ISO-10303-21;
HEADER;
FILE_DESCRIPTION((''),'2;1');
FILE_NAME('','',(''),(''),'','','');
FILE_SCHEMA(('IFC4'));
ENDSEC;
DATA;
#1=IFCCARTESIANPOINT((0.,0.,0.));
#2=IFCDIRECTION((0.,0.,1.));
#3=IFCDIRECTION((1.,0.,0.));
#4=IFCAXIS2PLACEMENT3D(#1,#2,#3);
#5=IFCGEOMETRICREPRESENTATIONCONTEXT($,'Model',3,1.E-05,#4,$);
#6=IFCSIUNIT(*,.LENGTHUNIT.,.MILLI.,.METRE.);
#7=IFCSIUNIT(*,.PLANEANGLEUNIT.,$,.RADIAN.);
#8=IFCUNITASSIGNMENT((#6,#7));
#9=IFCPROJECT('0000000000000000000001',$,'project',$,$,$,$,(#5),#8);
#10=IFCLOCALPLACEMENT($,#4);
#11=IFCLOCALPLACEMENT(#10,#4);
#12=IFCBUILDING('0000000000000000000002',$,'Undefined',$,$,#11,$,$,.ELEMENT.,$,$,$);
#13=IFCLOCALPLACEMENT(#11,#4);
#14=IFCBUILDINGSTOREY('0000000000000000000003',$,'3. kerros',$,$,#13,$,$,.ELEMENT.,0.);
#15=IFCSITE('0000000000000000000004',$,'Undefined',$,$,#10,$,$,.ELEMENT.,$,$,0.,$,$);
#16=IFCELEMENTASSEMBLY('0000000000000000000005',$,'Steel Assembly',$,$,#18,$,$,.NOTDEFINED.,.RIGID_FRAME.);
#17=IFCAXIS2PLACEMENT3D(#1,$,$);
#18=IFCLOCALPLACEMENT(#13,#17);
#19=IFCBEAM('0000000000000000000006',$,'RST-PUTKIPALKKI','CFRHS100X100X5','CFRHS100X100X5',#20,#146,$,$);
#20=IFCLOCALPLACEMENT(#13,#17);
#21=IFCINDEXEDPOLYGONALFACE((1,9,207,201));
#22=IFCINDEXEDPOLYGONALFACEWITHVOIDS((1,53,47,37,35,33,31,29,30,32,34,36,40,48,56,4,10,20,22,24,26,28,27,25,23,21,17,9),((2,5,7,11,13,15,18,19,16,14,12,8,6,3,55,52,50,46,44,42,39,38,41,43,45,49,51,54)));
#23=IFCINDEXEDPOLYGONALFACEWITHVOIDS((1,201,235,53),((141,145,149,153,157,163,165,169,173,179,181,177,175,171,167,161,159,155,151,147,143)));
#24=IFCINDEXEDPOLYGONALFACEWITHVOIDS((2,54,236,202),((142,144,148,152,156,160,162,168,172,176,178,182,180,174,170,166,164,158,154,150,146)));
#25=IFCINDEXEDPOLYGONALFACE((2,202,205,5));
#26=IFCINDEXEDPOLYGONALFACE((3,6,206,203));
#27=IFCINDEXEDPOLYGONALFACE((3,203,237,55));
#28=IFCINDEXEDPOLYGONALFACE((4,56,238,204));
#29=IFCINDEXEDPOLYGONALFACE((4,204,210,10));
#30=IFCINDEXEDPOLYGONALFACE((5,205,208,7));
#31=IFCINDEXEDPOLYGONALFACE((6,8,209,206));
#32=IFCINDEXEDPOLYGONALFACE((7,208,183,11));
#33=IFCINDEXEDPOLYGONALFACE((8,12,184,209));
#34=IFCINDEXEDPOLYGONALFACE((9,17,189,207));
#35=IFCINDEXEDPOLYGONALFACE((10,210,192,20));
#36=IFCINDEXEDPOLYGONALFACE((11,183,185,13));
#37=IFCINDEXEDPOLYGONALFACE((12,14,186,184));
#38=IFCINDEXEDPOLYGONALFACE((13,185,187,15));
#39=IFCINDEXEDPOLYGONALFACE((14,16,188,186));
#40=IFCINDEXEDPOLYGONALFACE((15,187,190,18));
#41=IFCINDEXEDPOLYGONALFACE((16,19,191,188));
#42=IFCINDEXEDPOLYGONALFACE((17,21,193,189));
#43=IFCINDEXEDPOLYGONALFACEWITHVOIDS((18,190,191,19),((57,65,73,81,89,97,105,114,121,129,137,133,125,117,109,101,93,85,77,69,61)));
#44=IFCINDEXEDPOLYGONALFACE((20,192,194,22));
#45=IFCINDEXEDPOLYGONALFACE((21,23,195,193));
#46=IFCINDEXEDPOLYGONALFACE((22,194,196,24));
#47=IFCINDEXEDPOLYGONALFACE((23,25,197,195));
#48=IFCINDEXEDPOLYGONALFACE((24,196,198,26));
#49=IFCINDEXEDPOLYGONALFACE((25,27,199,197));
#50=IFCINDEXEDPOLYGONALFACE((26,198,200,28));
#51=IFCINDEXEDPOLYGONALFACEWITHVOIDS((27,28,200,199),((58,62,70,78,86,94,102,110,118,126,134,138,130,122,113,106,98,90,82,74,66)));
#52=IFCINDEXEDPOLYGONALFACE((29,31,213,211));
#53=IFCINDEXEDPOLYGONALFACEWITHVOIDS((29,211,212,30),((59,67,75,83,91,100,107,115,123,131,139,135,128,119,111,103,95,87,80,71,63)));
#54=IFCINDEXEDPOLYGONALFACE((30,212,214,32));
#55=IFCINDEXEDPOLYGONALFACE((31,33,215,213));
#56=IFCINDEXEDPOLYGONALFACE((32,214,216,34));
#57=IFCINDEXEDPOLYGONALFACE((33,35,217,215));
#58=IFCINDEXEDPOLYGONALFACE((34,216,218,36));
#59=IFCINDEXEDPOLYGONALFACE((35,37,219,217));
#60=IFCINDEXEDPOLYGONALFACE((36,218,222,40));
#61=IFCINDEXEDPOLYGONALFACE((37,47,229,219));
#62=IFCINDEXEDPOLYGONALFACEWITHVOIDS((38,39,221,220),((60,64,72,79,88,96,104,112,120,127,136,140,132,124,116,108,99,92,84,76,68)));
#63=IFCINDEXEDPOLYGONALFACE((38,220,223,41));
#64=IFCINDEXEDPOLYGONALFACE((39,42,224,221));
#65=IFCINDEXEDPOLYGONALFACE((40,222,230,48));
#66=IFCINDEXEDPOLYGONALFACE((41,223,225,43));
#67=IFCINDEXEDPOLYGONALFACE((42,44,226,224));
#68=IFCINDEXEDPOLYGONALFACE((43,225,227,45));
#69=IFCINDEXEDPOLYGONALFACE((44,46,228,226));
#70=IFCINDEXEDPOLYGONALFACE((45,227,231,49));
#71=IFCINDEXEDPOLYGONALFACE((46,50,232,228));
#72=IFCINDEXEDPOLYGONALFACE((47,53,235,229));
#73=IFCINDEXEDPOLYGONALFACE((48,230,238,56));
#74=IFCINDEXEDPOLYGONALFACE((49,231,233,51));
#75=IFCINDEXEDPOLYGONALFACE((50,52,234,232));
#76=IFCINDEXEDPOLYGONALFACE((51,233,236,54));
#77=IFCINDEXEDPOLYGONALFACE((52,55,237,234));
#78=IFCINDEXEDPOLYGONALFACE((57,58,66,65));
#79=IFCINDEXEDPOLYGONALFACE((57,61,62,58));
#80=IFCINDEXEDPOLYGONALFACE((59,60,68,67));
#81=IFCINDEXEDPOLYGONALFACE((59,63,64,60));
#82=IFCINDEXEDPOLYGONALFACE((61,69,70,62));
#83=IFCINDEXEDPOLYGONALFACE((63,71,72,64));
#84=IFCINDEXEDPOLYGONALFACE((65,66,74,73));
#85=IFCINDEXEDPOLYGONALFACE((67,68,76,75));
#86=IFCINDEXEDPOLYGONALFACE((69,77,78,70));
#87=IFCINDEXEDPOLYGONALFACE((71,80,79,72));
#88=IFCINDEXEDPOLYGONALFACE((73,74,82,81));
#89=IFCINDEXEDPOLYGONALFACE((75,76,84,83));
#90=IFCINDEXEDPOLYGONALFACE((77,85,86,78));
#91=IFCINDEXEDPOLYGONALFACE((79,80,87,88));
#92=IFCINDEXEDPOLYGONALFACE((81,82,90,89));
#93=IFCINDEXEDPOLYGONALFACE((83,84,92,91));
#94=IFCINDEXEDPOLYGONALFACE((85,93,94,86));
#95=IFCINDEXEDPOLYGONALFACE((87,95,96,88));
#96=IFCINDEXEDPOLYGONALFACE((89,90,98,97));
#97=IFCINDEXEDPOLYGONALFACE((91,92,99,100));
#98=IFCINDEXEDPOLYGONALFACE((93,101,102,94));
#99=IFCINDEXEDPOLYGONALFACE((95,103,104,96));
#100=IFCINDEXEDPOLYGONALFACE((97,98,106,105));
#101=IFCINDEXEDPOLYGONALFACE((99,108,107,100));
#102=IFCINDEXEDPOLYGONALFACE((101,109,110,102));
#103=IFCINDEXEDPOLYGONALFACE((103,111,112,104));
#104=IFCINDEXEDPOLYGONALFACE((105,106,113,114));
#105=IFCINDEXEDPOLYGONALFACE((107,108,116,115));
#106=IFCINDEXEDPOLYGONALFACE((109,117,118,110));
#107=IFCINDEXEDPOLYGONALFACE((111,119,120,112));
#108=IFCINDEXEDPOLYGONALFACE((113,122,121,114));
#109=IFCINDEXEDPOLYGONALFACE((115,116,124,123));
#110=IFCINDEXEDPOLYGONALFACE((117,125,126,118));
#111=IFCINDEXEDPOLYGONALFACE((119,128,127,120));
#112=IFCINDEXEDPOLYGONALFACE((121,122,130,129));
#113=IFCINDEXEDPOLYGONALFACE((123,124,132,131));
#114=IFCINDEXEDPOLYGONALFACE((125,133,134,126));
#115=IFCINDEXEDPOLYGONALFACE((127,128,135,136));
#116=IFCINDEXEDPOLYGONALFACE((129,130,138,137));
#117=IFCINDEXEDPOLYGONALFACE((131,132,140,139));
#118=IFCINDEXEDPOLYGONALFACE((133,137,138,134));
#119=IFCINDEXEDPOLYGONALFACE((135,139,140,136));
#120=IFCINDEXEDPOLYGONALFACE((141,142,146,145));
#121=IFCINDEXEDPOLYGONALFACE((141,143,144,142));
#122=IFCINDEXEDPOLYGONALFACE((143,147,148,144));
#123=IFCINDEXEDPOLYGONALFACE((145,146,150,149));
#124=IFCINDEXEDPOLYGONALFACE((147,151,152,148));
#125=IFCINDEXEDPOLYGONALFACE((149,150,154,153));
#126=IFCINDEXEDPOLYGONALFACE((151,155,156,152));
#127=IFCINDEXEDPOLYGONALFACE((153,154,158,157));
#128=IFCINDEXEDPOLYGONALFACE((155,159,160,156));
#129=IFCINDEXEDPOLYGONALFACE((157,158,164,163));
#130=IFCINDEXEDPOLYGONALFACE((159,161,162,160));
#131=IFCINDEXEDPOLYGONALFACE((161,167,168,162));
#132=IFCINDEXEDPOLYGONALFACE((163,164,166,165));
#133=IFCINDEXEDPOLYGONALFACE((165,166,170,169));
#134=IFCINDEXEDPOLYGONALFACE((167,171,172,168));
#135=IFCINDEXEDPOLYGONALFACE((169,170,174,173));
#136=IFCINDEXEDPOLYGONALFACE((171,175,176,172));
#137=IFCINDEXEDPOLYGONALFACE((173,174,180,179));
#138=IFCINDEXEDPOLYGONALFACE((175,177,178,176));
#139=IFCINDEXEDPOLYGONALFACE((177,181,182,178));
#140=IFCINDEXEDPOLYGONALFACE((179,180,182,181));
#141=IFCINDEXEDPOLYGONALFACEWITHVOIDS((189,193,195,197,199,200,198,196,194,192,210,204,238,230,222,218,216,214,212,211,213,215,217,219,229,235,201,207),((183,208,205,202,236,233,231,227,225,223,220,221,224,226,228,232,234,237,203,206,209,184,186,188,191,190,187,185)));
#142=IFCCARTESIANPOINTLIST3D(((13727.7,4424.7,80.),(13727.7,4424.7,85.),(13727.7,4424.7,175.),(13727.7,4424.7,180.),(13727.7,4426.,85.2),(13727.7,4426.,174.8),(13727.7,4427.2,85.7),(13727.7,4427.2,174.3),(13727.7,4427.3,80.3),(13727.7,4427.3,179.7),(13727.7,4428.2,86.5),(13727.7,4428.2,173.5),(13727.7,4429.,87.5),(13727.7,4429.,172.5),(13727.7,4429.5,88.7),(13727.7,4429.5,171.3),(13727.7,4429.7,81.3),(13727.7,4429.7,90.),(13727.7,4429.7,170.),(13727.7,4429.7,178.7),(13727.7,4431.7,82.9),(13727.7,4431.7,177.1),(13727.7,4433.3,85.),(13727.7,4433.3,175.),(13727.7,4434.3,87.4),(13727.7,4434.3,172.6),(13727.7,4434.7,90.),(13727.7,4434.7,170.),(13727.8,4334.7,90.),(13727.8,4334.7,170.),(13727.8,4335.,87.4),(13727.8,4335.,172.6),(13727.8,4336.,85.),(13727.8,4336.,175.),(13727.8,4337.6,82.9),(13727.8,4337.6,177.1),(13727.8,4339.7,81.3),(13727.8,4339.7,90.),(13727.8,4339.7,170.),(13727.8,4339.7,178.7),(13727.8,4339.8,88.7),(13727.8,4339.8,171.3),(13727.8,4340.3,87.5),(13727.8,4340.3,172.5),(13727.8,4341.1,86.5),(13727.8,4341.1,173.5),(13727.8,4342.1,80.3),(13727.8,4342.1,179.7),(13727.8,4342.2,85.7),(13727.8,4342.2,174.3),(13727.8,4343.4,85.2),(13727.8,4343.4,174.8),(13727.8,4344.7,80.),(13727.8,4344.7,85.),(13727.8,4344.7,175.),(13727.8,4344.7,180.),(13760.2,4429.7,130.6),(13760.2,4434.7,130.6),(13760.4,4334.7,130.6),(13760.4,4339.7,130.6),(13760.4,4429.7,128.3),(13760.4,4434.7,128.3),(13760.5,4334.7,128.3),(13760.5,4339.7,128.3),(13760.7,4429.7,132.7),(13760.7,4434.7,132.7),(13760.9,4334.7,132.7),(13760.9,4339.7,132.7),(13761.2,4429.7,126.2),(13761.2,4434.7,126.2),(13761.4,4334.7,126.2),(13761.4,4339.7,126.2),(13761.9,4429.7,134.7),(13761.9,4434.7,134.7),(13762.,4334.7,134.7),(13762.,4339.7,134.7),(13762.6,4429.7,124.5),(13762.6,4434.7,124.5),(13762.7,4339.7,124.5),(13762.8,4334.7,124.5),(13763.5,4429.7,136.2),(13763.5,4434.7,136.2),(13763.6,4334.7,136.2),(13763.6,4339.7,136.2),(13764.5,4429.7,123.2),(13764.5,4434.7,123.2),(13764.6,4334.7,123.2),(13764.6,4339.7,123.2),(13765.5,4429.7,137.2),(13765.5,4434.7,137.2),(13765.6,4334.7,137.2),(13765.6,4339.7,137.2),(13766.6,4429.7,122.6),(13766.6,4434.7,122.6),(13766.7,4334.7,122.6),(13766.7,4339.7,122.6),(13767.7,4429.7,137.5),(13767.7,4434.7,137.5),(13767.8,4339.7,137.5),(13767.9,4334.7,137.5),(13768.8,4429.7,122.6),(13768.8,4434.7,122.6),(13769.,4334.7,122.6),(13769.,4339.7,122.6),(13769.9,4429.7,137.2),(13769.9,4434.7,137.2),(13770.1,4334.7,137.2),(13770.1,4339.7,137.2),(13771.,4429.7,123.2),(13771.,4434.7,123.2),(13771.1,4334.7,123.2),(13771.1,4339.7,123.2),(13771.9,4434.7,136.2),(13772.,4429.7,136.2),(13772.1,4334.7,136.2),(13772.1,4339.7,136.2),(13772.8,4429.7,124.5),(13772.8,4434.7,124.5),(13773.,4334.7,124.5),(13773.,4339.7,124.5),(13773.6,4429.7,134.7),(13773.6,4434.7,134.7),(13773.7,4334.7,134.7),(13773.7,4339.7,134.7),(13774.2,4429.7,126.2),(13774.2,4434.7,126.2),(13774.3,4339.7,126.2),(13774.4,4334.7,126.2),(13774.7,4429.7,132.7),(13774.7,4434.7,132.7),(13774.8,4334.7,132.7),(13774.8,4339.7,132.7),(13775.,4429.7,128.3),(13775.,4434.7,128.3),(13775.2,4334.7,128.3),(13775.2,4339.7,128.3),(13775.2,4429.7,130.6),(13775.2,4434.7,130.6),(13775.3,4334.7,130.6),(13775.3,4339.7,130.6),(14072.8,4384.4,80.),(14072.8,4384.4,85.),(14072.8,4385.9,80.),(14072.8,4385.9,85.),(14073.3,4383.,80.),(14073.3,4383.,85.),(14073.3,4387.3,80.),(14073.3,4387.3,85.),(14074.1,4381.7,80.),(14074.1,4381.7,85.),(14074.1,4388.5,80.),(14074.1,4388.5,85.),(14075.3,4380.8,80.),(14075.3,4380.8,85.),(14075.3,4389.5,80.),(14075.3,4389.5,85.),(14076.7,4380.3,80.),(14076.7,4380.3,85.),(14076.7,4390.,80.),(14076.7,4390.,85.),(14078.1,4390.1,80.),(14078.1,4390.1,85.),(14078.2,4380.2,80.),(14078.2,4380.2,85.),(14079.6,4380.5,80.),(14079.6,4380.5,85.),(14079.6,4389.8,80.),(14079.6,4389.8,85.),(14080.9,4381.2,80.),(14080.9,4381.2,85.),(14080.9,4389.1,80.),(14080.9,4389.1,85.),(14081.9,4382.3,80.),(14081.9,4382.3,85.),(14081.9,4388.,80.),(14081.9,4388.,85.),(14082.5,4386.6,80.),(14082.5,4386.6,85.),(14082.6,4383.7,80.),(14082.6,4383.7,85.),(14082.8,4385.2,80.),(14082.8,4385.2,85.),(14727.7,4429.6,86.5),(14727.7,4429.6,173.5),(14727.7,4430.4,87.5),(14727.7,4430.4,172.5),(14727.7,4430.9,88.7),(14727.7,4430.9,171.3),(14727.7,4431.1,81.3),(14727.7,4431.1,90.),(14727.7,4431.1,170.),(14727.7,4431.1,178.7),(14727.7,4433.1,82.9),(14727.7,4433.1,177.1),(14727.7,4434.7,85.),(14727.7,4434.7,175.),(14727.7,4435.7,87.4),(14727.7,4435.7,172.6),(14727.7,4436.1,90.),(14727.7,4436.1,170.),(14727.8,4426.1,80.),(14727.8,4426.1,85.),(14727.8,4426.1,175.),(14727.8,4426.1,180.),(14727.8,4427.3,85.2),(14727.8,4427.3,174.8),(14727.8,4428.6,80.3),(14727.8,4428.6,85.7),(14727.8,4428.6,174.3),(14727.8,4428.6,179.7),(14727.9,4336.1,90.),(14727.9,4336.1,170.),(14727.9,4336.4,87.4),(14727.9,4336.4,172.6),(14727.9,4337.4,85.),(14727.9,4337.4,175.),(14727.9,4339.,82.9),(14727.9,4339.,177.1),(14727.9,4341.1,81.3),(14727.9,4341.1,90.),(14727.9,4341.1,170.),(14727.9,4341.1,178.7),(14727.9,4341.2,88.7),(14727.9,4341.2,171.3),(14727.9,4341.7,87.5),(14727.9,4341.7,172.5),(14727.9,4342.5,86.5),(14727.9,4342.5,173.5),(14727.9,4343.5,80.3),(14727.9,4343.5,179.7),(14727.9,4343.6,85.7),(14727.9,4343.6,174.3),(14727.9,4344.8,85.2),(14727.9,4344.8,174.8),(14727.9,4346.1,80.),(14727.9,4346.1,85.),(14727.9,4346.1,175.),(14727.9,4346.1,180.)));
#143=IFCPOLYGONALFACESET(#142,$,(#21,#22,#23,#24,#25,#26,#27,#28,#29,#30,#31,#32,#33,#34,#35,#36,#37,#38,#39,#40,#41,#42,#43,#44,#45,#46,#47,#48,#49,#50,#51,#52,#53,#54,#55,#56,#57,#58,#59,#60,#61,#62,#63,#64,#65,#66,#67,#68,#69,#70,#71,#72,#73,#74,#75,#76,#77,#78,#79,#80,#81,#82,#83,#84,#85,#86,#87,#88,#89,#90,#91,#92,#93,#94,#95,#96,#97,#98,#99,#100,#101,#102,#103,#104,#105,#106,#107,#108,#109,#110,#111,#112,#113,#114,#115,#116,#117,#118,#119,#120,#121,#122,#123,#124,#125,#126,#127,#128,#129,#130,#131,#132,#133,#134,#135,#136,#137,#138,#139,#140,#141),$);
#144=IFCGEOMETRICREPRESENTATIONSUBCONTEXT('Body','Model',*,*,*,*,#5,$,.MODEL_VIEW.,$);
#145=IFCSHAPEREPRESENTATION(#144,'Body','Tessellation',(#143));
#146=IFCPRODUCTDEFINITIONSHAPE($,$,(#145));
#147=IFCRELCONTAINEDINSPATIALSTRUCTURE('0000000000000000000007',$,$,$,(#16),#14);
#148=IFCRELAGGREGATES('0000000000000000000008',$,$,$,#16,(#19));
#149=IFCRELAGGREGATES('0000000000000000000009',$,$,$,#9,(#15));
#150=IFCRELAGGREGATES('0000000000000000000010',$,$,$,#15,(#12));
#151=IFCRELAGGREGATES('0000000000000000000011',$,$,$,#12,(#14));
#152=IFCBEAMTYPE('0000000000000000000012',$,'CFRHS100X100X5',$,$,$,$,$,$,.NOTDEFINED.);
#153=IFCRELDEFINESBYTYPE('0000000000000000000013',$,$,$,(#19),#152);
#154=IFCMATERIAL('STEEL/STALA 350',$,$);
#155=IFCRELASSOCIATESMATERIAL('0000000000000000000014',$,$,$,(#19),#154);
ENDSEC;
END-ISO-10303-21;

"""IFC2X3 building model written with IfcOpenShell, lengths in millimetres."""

from ifc_helpers import new_model, si_unit, frame, origin_with_axes, origin_2d_with_axis, place, context, subcontext, project, spatial, hollow_rectangle, circle, extrude, boolean, material, type_object, element, aggregate, save


model = new_model("IFC2X3")

# Units and contexts
model_context = context("Model", 3, precision=1e-05, world=origin_with_axes())
body_context = subcontext(model_context, "Body", "Model", "MODEL_VIEW")
ifc_project = project(units=[si_unit("LENGTHUNIT", "METRE", prefix="MILLI"), si_unit("PLANEANGLEUNIT", "RADIAN")], contexts=[model_context])

# Site, building, storey
site_placement = place(None, origin_with_axes())
site = spatial("IfcSite", under=ifc_project, at=site_placement, Name="Undefined", CompositionType="ELEMENT", RefElevation=0.0)
building_placement = place(site_placement, origin_with_axes())
building = spatial("IfcBuilding", under=site, at=building_placement, Name="Undefined", CompositionType="ELEMENT")
storey_placement = place(building_placement, origin_with_axes())
storey = spatial("IfcBuildingStorey", under=building, at=storey_placement, Name="3. kerros", CompositionType="ELEMENT", Elevation=0.0)

# Element assembly, beam
assembly_1_placement = place(storey_placement, origin_with_axes())
assembly_1 = element("IfcElementAssembly", 1, at=assembly_1_placement, inside=storey, Name="Steel Assembly", AssemblyPlace="NOTDEFINED", PredefinedType="RIGID_FRAME")
ifc_material_1 = material(Name="STEEL/STALA 350")
beam_type_1 = type_object("IfcBeamType", Name="CFRHS100X100X5", PredefinedType="NOTDEFINED")
beam_1_placement = place(assembly_1_placement, frame((13727.8, 4384.7, 130.0), z_axis=(0.0, 0.0, 1.0), x_axis=(0.999999, 0.001383, 0.0)))
beam_1 = element("IfcBeam", 2, at=beam_1_placement, type_object=beam_type_1, material=ifc_material_1, Name="RST-PUTKIPALKKI", Description="CFRHS100X100X5", ObjectType="CFRHS100X100X5", context=body_context, shape_type="CSG", body=[
    boolean("DIFFERENCE", boolean("DIFFERENCE", extrude(hollow_rectangle(XDim=100.0, YDim=100.0, WallThickness=5.0, InnerFilletRadius=5.0, OuterFilletRadius=10.0, at=origin_2d_with_axis()), frame((1000.0, 0.0, 0.0), z_axis=(-1.0, 0.0, 0.0), x_axis=(0.0, -1.0, 0.0)), (0.0, 0.0, 1.0), 1000.0), extrude(circle(Radius=7.5, at=origin_2d_with_axis()), frame((40.0, -69.8, 0.0), z_axis=(0.000031, 1.0, 0.0), x_axis=(0.0, 0.0, 1.0)), (0.0, 0.0, 1.0), 140.0)), extrude(circle(Radius=5.0, at=origin_2d_with_axis()), frame((350.0, 0.0, -40.0), z_axis=(0.0, 0.0, -1.0), x_axis=(1.0, -0.000035, 0.0)), (0.0, 0.0, 1.0), 30.0)),
])
aggregate(assembly_1, [beam_1])

save(model, "model.ifc")
